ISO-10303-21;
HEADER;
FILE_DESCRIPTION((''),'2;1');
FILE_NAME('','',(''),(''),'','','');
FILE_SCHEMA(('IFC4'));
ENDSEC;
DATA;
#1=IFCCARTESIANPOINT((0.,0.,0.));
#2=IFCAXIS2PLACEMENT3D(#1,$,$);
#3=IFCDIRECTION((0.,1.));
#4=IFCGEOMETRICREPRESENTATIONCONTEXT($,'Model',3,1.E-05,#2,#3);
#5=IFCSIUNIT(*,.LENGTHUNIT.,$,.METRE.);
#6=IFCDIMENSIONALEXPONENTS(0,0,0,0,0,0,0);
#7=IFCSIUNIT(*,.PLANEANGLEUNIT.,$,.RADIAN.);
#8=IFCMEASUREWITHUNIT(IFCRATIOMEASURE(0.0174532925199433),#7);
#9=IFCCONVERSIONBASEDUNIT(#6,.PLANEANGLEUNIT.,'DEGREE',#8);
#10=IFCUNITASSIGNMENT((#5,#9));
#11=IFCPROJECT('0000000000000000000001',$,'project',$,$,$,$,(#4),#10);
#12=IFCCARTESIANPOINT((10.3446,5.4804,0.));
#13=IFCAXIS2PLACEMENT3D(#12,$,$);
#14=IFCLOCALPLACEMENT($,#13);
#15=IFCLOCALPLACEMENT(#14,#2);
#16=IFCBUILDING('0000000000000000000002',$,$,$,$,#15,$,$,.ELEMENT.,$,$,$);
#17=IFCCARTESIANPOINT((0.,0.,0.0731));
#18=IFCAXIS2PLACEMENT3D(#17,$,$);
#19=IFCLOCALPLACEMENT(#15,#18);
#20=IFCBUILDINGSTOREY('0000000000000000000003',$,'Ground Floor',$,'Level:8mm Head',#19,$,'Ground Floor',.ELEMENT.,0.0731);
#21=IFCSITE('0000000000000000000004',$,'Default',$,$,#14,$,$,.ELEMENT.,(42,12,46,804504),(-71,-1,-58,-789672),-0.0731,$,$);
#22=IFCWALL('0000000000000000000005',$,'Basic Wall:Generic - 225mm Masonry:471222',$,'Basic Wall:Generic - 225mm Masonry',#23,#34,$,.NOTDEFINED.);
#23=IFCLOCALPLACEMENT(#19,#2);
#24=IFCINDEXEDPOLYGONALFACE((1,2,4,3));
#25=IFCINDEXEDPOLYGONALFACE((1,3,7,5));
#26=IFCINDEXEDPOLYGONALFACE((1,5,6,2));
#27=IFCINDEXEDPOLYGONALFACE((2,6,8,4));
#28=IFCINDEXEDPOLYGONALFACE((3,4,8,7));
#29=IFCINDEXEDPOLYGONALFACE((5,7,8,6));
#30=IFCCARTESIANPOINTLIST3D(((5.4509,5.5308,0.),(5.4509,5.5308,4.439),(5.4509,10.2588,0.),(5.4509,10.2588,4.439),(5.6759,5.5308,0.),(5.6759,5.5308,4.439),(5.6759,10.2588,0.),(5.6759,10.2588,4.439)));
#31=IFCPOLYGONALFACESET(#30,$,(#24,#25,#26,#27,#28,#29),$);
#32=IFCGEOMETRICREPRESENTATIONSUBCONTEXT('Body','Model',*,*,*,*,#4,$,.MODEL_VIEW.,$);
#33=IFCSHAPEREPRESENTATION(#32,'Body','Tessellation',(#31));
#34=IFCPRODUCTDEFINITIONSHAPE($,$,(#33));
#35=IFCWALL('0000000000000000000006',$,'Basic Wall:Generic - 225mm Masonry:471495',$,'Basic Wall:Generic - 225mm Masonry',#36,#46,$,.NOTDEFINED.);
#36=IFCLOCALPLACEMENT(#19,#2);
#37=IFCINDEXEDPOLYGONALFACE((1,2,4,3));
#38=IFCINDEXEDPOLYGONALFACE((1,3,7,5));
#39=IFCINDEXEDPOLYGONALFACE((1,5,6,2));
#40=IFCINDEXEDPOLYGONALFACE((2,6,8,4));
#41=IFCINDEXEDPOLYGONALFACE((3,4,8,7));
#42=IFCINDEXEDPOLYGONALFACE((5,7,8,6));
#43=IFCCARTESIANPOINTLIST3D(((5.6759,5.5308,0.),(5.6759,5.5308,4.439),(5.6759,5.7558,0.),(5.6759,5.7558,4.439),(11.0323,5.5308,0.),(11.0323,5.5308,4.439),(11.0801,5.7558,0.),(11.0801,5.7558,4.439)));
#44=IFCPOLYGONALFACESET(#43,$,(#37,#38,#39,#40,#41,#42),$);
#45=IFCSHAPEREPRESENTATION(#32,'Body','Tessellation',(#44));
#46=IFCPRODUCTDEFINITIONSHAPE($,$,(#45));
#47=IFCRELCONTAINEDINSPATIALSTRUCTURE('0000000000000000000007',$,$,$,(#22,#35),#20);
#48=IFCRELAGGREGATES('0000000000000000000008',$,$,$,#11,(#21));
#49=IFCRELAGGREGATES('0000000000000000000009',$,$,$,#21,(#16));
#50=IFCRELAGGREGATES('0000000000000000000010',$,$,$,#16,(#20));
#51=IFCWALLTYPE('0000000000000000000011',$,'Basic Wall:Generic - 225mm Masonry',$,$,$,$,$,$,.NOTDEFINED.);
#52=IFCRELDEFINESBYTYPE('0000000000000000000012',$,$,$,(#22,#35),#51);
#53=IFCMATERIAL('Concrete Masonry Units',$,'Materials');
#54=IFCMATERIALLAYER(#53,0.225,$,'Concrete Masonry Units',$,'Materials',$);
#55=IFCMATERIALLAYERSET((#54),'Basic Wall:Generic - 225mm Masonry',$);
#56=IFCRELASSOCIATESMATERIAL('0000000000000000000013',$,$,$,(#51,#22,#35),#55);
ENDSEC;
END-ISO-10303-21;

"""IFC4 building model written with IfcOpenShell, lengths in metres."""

from ifc_helpers import new_model, entity, si_unit, converted_unit, direction, frame, frame_2d, origin, place, context, subcontext, project, spatial, polyline, rectangle, outline, extrude, clip, bounded_halfspace, material, layer, layer_set, layer_usage, type_object, element, save


model = new_model("IFC4")

# Units and contexts
model_context = context("Model", 3, precision=1e-05, world=origin(), true_north=direction((0.0, 1.0)))
body_context = subcontext(model_context, "Body", "Model", "MODEL_VIEW")
ifc_project = project(units=[si_unit("LENGTHUNIT", "METRE"), converted_unit("PLANEANGLEUNIT", "DEGREE", entity("IfcRatioMeasure", 0.0174532925199433), si_unit("PLANEANGLEUNIT", "RADIAN"), dimensions=[0, 0, 0, 0, 0, 0, 0])], contexts=[model_context])

# Site, building, storey
site_placement = place(None, frame((10.3446, 5.4804, 0.0)))
site = spatial("IfcSite", under=ifc_project, at=site_placement, Name="Default", CompositionType="ELEMENT", RefLatitude=(42, 12, 46, 804504), RefLongitude=(-71, -1, -58, -789672), RefElevation=-0.0731)
building_placement = place(site_placement, origin())
building = spatial("IfcBuilding", under=site, at=building_placement, CompositionType="ELEMENT")
storey_placement = place(building_placement, frame((0.0, 0.0, 0.0731)))
storey = spatial("IfcBuildingStorey", under=building, at=storey_placement, Name="Ground Floor", ObjectType="Level:8mm Head", LongName="Ground Floor", CompositionType="ELEMENT", Elevation=0.0731)

# Walls
ifc_material_1 = material(Name="Concrete Masonry Units", Category="Materials")
ifc_layer_1 = layer(ifc_material_1, 0.225, Name="Concrete Masonry Units", Category="Materials")
ifc_layer_set_1 = layer_set([ifc_layer_1], Name="Basic Wall:Generic - 225mm Masonry")
wall_type = type_object("IfcWallType", Name="Basic Wall:Generic - 225mm Masonry", PredefinedType="NOTDEFINED", material=ifc_layer_set_1)
ifc_layer_usage_1 = layer_usage(ifc_layer_set_1, "AXIS2", "NEGATIVE", 0.1125)
wall_1_placement = place(storey_placement, frame((5.5634, 10.2588, 0.0), z_axis=(0.0, 0.0, 1.0), x_axis=(0.0, -1.0, 0.0)))
element("IfcWall", 1, at=wall_1_placement, inside=storey, type_object=wall_type, material=ifc_layer_usage_1, Name="Basic Wall:Generic - 225mm Masonry:471222", ObjectType="Basic Wall:Generic - 225mm Masonry", PredefinedType="NOTDEFINED", context=body_context, shape_type="Clipping", body=[
    clip(extrude(rectangle(XDim=4.728, YDim=0.225, at=frame_2d((2.364, 0.0), x_axis=(-1.0, 0.0))), origin(), (0.0, 0.0, 1.0), 4.439), bounded_halfspace(frame((0.0, -0.1125, 4.439), z_axis=(0.0, 0.0, -1.0), x_axis=(0.978148, -0.207912, 0.0)), True, frame((0.0, -0.1125, 4.439)), polyline([(0.0, 0.0), (4.728, 0.0), (4.728, 0.225), (4.503, 0.225), (0.0, 0.225), (0.0, 0.0)]))),
])
ifc_layer_usage_2 = layer_usage(ifc_layer_set_1, "AXIS2", "NEGATIVE", 0.1125)
wall_2_placement = place(storey_placement, frame((5.6759, 5.6433, 0.0)))
element("IfcWall", 2, at=wall_2_placement, inside=storey, type_object=wall_type, material=ifc_layer_usage_2, Name="Basic Wall:Generic - 225mm Masonry:471495", ObjectType="Basic Wall:Generic - 225mm Masonry", PredefinedType="NOTDEFINED", context=body_context, shape_type="Clipping", body=[
    clip(extrude(outline(polyline([(5.3564, -0.1125), (5.4043, 0.1125), (0.0, 0.1125), (0.0, -0.1125), (5.3564, -0.1125)])), origin(), (0.0, 0.0, 1.0), 4.439), bounded_halfspace(frame((0.0, -0.1125, 4.439), z_axis=(0.0, 0.0, -1.0), x_axis=(-0.207912, -0.978148, 0.0)), True, frame((0.0, -0.1125, 4.439)), polyline([(0.0, 0.0), (5.3564, 0.0), (5.4043, 0.225), (0.0, 0.225), (0.0, 0.0)]))),
])

save(model, "model.ifc")
